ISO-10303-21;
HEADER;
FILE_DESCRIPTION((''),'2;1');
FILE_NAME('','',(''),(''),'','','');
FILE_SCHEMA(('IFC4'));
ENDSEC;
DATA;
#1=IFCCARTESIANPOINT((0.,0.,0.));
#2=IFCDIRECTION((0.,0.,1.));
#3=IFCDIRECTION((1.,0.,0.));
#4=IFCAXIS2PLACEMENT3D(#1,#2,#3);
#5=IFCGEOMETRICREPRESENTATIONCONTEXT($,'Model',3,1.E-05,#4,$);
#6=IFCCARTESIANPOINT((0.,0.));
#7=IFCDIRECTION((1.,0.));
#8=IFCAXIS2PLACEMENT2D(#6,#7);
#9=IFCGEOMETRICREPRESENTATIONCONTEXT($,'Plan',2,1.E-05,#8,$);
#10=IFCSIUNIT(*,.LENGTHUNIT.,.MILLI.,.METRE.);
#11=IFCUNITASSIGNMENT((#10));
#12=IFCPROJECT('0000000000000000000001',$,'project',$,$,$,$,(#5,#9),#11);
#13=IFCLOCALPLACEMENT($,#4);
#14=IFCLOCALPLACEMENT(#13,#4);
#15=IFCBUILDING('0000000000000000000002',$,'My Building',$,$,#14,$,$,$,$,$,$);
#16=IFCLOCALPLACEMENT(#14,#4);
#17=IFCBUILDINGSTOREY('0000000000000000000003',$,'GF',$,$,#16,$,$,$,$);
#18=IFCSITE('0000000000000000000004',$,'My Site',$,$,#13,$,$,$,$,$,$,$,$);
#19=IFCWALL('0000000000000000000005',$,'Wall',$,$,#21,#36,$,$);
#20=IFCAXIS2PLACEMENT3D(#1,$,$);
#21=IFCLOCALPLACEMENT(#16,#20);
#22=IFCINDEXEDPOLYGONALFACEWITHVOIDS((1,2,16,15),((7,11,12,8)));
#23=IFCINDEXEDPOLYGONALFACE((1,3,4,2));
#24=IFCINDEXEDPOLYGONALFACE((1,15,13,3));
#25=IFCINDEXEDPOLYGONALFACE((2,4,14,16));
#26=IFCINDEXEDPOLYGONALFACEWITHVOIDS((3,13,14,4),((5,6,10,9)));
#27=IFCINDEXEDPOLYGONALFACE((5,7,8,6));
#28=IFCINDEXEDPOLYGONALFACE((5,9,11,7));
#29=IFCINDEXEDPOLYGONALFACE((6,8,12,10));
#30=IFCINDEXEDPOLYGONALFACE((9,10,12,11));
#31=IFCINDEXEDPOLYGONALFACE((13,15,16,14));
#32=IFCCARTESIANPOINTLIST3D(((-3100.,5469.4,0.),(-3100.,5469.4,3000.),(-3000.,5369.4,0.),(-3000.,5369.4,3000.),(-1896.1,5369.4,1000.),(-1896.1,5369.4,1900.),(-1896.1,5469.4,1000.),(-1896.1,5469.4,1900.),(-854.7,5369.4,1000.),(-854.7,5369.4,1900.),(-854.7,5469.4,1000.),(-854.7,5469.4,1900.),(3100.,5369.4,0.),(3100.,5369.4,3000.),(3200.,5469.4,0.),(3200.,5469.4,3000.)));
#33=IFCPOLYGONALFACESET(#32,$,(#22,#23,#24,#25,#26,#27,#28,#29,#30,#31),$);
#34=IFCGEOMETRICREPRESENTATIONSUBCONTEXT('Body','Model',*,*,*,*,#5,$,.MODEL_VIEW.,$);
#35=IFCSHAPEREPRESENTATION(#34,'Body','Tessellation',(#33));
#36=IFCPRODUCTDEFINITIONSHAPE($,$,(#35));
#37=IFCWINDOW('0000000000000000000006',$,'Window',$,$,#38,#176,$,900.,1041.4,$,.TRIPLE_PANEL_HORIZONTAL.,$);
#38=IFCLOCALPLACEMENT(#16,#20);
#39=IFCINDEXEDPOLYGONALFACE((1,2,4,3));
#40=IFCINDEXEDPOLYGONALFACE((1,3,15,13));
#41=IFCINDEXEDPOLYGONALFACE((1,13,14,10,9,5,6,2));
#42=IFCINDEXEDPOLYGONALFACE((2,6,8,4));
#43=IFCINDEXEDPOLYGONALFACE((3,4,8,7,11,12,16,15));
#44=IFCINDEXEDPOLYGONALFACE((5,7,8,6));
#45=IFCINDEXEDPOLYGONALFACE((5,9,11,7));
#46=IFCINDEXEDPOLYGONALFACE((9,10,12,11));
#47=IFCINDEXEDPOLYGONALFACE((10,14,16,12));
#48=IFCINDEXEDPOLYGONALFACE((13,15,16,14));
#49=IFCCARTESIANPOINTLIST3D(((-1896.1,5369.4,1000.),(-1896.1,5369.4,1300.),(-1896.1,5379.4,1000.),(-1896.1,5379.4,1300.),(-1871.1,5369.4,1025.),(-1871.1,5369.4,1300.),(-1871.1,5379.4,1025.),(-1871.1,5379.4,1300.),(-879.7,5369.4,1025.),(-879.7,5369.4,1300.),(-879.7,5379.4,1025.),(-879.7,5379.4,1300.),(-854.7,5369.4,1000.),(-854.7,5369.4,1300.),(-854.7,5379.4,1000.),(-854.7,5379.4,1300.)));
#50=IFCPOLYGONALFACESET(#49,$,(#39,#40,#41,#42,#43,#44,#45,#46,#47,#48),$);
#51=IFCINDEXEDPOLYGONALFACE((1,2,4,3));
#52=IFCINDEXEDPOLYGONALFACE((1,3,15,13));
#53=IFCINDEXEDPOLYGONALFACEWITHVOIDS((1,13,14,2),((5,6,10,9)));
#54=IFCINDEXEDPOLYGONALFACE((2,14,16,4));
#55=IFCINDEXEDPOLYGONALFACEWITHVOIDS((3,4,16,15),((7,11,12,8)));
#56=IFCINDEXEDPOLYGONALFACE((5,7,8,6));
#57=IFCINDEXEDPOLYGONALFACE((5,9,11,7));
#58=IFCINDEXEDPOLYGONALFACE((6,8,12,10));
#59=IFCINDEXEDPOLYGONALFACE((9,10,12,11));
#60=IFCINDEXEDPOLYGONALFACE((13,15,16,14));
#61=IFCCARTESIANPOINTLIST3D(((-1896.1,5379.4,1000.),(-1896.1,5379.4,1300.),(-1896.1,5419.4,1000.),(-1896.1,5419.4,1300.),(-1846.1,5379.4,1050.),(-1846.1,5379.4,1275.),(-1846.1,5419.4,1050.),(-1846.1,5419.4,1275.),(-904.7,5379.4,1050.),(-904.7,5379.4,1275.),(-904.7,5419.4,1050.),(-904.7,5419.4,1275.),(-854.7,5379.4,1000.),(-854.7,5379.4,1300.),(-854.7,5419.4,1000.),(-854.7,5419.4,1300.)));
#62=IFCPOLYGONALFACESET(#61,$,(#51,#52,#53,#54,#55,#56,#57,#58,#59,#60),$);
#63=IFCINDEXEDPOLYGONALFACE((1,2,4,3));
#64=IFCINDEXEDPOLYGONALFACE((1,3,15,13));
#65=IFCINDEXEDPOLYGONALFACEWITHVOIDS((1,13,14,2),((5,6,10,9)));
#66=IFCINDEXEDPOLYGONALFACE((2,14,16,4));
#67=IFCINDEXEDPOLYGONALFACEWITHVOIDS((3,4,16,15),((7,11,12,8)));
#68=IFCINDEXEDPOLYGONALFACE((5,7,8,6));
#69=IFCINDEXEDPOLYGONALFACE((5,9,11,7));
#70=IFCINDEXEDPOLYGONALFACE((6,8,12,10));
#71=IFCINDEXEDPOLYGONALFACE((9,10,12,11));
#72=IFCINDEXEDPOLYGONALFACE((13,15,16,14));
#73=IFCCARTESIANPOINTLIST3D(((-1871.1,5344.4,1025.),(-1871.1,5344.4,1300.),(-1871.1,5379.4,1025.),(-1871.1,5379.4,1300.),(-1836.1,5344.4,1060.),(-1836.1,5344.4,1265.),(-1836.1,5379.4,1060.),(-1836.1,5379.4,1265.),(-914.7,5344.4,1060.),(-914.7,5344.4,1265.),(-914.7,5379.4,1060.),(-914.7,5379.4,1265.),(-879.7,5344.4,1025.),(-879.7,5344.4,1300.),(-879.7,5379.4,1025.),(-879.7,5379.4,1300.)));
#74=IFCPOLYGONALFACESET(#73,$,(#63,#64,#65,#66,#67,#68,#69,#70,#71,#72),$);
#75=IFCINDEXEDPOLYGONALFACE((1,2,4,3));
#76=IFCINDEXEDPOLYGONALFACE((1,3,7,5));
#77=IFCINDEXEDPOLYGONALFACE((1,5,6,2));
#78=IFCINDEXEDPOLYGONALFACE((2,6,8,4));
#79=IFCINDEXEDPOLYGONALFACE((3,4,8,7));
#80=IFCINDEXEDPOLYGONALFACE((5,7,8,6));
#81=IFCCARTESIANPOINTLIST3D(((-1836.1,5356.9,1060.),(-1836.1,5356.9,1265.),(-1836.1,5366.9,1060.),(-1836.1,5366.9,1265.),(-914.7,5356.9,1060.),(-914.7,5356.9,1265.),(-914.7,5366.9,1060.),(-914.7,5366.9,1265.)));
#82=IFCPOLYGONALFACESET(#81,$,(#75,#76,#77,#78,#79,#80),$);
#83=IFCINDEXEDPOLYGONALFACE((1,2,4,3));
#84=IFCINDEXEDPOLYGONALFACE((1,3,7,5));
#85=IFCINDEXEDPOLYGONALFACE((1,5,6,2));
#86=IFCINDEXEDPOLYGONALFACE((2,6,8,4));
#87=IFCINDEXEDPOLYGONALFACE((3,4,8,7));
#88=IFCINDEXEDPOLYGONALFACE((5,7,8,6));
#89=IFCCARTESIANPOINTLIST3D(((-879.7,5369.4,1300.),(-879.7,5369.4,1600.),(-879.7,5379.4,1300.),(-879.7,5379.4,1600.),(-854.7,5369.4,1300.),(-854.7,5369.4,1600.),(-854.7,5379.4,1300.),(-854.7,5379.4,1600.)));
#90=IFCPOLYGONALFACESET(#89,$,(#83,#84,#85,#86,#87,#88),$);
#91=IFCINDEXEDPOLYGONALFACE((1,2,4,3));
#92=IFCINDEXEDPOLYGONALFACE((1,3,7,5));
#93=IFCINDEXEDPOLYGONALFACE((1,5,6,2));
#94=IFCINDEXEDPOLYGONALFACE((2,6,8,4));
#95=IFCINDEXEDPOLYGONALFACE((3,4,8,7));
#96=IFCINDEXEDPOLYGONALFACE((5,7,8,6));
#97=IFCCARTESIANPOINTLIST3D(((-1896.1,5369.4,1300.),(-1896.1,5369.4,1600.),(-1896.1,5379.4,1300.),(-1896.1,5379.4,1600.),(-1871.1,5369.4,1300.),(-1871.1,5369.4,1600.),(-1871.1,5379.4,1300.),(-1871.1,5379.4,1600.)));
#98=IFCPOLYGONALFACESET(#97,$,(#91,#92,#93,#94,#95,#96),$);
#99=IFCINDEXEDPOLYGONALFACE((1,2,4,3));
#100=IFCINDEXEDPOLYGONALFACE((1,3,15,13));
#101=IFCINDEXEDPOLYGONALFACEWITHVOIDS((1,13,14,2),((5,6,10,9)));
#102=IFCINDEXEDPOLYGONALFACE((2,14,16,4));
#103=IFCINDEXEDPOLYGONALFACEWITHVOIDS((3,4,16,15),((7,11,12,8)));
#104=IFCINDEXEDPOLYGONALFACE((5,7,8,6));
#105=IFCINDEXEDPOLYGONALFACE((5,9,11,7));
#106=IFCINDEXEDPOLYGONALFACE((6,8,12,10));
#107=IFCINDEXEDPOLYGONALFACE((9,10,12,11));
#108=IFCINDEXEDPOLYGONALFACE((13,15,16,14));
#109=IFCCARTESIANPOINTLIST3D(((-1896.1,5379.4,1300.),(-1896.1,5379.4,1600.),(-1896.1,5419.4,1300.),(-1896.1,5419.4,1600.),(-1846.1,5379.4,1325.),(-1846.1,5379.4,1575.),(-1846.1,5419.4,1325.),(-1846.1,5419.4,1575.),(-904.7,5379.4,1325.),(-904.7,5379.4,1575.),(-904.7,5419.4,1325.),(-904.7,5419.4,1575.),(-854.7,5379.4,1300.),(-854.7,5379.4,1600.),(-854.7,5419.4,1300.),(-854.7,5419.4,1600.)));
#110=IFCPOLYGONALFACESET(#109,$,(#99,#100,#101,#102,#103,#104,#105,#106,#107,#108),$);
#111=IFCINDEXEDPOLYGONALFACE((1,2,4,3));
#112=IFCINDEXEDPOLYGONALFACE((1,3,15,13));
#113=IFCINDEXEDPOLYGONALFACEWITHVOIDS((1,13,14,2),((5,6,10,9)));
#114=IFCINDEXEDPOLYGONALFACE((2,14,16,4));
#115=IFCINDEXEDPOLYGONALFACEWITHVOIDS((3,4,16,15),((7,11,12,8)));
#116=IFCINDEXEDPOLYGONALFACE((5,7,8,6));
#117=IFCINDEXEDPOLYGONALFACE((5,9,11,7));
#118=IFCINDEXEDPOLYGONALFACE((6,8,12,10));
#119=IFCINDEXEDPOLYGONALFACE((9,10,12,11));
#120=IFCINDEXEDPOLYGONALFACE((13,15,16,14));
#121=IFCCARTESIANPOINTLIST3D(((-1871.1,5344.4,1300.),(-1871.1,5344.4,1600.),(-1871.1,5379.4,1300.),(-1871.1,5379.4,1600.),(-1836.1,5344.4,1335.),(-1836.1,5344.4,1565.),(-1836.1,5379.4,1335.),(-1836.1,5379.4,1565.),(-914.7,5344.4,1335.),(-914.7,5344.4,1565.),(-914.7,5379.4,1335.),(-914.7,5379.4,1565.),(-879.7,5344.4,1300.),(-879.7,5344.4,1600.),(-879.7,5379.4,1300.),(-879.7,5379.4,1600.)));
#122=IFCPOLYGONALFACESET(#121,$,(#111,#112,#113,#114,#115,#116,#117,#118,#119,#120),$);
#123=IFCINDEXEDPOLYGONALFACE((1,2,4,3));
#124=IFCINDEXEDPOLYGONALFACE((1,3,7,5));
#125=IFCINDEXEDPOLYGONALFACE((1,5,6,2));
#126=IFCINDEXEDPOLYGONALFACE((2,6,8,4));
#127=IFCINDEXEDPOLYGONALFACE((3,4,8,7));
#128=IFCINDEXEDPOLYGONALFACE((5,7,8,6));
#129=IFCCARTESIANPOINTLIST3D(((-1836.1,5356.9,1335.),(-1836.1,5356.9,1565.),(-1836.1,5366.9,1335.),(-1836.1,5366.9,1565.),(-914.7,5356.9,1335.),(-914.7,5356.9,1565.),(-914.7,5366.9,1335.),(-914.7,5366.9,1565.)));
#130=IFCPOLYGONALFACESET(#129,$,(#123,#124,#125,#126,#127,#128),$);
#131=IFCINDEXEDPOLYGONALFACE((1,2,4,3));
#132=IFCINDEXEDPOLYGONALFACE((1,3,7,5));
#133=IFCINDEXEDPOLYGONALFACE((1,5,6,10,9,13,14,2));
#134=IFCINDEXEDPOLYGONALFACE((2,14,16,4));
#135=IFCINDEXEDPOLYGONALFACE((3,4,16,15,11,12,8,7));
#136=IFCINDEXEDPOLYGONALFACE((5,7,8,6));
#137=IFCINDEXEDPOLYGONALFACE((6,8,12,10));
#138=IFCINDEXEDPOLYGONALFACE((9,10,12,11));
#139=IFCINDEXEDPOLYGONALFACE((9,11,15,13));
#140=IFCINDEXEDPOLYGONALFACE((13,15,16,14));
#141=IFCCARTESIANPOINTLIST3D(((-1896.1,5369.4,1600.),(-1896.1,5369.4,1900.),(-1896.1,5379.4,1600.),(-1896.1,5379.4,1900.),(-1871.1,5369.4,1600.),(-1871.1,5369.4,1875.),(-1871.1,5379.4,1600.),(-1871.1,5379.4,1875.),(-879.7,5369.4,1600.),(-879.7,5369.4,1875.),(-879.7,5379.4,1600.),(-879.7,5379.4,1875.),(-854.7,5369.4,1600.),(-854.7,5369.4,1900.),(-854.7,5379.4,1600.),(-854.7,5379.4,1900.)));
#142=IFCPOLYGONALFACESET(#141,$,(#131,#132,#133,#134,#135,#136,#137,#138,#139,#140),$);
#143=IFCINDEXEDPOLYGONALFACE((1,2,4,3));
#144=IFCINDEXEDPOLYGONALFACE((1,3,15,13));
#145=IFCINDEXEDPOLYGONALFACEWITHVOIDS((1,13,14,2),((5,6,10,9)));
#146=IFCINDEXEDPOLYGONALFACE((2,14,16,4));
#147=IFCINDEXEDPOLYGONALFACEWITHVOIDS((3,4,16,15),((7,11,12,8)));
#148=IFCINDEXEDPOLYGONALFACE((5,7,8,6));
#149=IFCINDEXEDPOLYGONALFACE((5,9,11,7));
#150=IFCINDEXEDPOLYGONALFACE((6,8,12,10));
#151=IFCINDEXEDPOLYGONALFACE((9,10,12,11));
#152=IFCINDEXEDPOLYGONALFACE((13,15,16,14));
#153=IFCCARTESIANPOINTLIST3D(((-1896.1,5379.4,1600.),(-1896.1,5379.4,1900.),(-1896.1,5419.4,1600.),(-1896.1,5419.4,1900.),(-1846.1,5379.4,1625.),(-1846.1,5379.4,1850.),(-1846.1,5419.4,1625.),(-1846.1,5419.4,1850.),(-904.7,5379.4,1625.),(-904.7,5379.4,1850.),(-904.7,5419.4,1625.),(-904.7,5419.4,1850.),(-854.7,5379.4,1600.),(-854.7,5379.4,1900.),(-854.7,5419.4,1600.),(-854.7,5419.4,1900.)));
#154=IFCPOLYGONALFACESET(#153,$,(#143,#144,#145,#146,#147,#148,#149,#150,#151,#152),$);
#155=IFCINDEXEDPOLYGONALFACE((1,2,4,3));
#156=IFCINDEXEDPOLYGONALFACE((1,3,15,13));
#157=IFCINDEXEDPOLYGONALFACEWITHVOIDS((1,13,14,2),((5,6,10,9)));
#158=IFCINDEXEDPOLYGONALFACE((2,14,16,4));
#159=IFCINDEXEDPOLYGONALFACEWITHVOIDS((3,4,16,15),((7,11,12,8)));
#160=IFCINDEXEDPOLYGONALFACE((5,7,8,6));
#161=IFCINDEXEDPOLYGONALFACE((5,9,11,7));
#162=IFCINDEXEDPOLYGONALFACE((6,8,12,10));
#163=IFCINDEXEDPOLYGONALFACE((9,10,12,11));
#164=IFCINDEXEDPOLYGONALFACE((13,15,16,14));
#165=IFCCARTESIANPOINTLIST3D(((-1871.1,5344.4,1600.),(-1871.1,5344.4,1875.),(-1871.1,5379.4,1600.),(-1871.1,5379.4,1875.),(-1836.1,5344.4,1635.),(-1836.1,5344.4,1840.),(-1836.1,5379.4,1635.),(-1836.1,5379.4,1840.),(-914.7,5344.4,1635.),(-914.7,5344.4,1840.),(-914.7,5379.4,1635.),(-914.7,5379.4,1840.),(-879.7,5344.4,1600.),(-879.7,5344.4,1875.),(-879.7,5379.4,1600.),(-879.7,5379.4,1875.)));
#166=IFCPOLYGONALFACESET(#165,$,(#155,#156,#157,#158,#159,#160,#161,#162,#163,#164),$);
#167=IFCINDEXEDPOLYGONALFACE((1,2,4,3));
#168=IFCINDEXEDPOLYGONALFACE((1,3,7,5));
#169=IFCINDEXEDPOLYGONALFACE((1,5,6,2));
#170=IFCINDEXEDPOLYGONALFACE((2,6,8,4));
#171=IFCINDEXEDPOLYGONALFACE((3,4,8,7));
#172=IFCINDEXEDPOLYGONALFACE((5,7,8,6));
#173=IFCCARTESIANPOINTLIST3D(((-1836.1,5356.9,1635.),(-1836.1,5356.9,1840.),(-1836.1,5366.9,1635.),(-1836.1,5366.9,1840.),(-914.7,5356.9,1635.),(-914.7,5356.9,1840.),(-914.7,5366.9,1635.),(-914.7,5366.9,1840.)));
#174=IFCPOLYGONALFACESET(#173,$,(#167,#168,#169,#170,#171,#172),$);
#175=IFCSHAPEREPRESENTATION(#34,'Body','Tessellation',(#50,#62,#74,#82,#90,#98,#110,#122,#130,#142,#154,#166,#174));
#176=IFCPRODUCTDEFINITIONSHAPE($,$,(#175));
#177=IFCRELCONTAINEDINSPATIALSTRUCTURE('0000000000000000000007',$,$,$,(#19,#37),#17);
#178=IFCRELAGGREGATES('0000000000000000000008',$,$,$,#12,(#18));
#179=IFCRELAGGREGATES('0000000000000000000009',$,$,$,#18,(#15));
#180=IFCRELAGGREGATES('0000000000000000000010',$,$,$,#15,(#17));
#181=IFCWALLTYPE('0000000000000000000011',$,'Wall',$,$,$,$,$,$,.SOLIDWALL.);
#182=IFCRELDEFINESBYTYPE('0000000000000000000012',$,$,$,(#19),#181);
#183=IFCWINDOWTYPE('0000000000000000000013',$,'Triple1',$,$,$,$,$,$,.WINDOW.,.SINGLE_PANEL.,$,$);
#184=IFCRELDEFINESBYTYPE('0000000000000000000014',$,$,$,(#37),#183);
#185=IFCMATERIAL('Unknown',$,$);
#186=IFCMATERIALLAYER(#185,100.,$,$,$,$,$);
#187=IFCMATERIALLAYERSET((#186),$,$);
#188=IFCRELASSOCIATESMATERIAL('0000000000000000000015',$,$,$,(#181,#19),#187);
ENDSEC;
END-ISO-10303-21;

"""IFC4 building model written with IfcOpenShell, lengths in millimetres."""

from ifc_helpers import new_model, entity, si_unit, frame, origin_with_axes, origin_2d_with_axis, place, context, subcontext, project, spatial, line, indexed_curve, outline, extrude, shape, source, transform, mapped, material, layer, layer_set, layer_usage, type_object, type_shapes, element, fill, save


model = new_model("IFC4")

# Units and contexts
model_context = context("Model", 3, precision=1e-05, world=origin_with_axes())
plan_context = context("Plan", 2, precision=1e-05, world=origin_2d_with_axis())
body_context_1 = subcontext(model_context, "Body", "Model", "MODEL_VIEW")
body_context_2 = subcontext(plan_context, "Body", "Plan", "PLAN_VIEW")
ifc_project = project(units=[si_unit("LENGTHUNIT", "METRE", prefix="MILLI")], contexts=[model_context, plan_context])

# Site, building, storey
site_placement = place(None, origin_with_axes())
site = spatial("IfcSite", under=ifc_project, at=site_placement, Name="My Site")
building_placement = place(site_placement, origin_with_axes())
building = spatial("IfcBuilding", under=site, at=building_placement, Name="My Building")
storey_placement = place(building_placement, origin_with_axes())
storey = spatial("IfcBuildingStorey", under=building, at=storey_placement, Name="GF")

# Shared definitions
ifc_material = material(Name="Unknown")

# Wall, opening, window
ifc_layer_1 = layer(ifc_material, 100.0)
ifc_layer_set_1 = layer_set([ifc_layer_1])
ifc_layer_usage_1 = layer_usage(ifc_layer_set_1, "AXIS2", "POSITIVE", 0.0)
wall_type = type_object("IfcWallType", Name="Wall", PredefinedType="SOLIDWALL", material=ifc_layer_set_1)
wall_1_placement = place(storey_placement, frame((-3100.0, 5369.4, 0.0), z_axis=(0.0, 0.0, 1.0), x_axis=(1.0, 0.0, 0.0)))
wall_1 = element("IfcWall", 1, at=wall_1_placement, inside=storey, type_object=wall_type, material=ifc_layer_usage_1, Name="Wall", context=body_context_1, shape_type="SweptSolid", body=[
    extrude(outline(indexed_curve([(100.0, 0.0), (0.0, 100.0), (6300.0, 100.0), (6200.0, 0.0)], segments=[line(1, 2, 3, 4, 1)])), origin_with_axes(), (0.0, 0.0, 1.0), 3000.0),
])
shared_shape_1 = source(origin_with_axes(), body_context_1, "Body", "SweptSolid", [
    extrude(outline(indexed_curve([(0.0, 0.0), (1041.4, 0.0), (1041.4, 900.0), (0.0, 900.0)], segments=[line(1, 2, 3, 4, 1)])), frame((0.0, -600.0, 0.0), z_axis=(0.0, -1.0, 0.0), x_axis=(1.0, 0.0, 0.0)), (0.0, 0.0, -1.0), 1200.0),
])
opening_1_placement = place(wall_1_placement, frame((2245.3, 100.0, 1000.0), z_axis=(0.0, 0.0, 1.0), x_axis=(-1.0, 0.0, 0.0)))
opening_1 = element("IfcOpeningElement", 2, at=opening_1_placement, cuts=wall_1, PredefinedType="OPENING", context=body_context_1, shape_type="MappedRepresentation", body=[
    mapped(shared_shape_1, transform((0.0, 0.0, 0.0), x_axis=(1.0, 0.0, 0.0), y_axis=(0.0, 1.0, 0.0), z_axis=(0.0, 0.0, 1.0), scale=1.0)),
])
window_type_1 = type_object("IfcWindowType", Name="Triple1", PartitioningType="SINGLE_PANEL", PredefinedType="WINDOW")
shared_shape_2 = source(origin_with_axes(), body_context_1, "Body", "SweptSolid", [
    extrude(outline(indexed_curve([(1041.4, 300.0), (1041.4, 0.0), (0.0, 0.0), (0.0, 300.0), (25.0, 300.0), (25.0, 25.0), (1016.4, 25.0), (1016.4, 300.0)], segments=[line(1, 2, 3, 4, 5, 6, 7, 8, 1)])), frame((0.0, 90.0, 0.0), z_axis=(0.0, -1.0, 0.0), x_axis=(1.0, 0.0, 0.0)), (0.0, 0.0, -1.0), 10.0),
    extrude(outline(indexed_curve([(0.0, 0.0), (1041.4, 0.0), (1041.4, 300.0), (0.0, 300.0)], segments=[line(1, 2, 3, 4, 1)]), holes=[indexed_curve([(50.0, 50.0), (991.4, 50.0), (991.4, 275.0), (50.0, 275.0)], segments=[line(1, 2, 3, 4, 1)])]), frame((0.0, 50.0, 0.0), z_axis=(0.0, -1.0, 0.0), x_axis=(1.0, 0.0, 0.0)), (0.0, 0.0, -1.0), 40.0),
    extrude(outline(indexed_curve([(0.0, 0.0), (991.4, 0.0), (991.4, 275.0), (0.0, 275.0)], segments=[line(1, 2, 3, 4, 1)]), holes=[indexed_curve([(35.0, 35.0), (956.4, 35.0), (956.4, 240.0), (35.0, 240.0)], segments=[line(1, 2, 3, 4, 1)])]), frame((25.0, 90.0, 25.0), z_axis=(0.0, -1.0, 0.0), x_axis=(1.0, 0.0, 0.0)), (0.0, 0.0, -1.0), 35.0),
    extrude(outline(indexed_curve([(35.0, 35.0), (956.4, 35.0), (956.4, 240.0), (35.0, 240.0)], segments=[line(1, 2, 3, 4, 1)])), frame((25.0, 102.5, 25.0), z_axis=(0.0, -1.0, 0.0), x_axis=(1.0, 0.0, 0.0)), (0.0, 0.0, -1.0), 10.0),
    extrude(outline(indexed_curve([(0.0, 0.0), (0.0, 300.0), (25.0, 300.0), (25.0, 0.0)], segments=[line(1, 2, 3, 4, 1)])), frame((0.0, 90.0, 300.0), z_axis=(0.0, -1.0, 0.0), x_axis=(1.0, 0.0, 0.0)), (0.0, 0.0, -1.0), 10.0),
    extrude(outline(indexed_curve([(1041.4, 300.0), (1041.4, 0.0), (1016.4, 0.0), (1016.4, 300.0)], segments=[line(1, 2, 3, 4, 1)])), frame((0.0, 90.0, 300.0), z_axis=(0.0, -1.0, 0.0), x_axis=(1.0, 0.0, 0.0)), (0.0, 0.0, -1.0), 10.0),
    extrude(outline(indexed_curve([(0.0, 0.0), (1041.4, 0.0), (1041.4, 300.0), (0.0, 300.0)], segments=[line(1, 2, 3, 4, 1)]), holes=[indexed_curve([(50.0, 25.0), (991.4, 25.0), (991.4, 275.0), (50.0, 275.0)], segments=[line(1, 2, 3, 4, 1)])]), frame((0.0, 50.0, 300.0), z_axis=(0.0, -1.0, 0.0), x_axis=(1.0, 0.0, 0.0)), (0.0, 0.0, -1.0), 40.0),
    extrude(outline(indexed_curve([(0.0, 0.0), (991.4, 0.0), (991.4, 300.0), (0.0, 300.0)], segments=[line(1, 2, 3, 4, 1)]), holes=[indexed_curve([(35.0, 35.0), (956.4, 35.0), (956.4, 265.0), (35.0, 265.0)], segments=[line(1, 2, 3, 4, 1)])]), frame((25.0, 90.0, 300.0), z_axis=(0.0, -1.0, 0.0), x_axis=(1.0, 0.0, 0.0)), (0.0, 0.0, -1.0), 35.0),
    extrude(outline(indexed_curve([(35.0, 35.0), (956.4, 35.0), (956.4, 265.0), (35.0, 265.0)], segments=[line(1, 2, 3, 4, 1)])), frame((25.0, 102.5, 300.0), z_axis=(0.0, -1.0, 0.0), x_axis=(1.0, 0.0, 0.0)), (0.0, 0.0, -1.0), 10.0),
    extrude(outline(indexed_curve([(0.0, 0.0), (0.0, 300.0), (1041.4, 300.0), (1041.4, 0.0), (1016.4, 0.0), (1016.4, 275.0), (25.0, 275.0), (25.0, 0.0)], segments=[line(1, 2, 3, 4, 5, 6, 7, 8, 1)])), frame((0.0, 90.0, 600.0), z_axis=(0.0, -1.0, 0.0), x_axis=(1.0, 0.0, 0.0)), (0.0, 0.0, -1.0), 10.0),
    extrude(outline(indexed_curve([(0.0, 0.0), (1041.4, 0.0), (1041.4, 300.0), (0.0, 300.0)], segments=[line(1, 2, 3, 4, 1)]), holes=[indexed_curve([(50.0, 25.0), (991.4, 25.0), (991.4, 250.0), (50.0, 250.0)], segments=[line(1, 2, 3, 4, 1)])]), frame((0.0, 50.0, 600.0), z_axis=(0.0, -1.0, 0.0), x_axis=(1.0, 0.0, 0.0)), (0.0, 0.0, -1.0), 40.0),
    extrude(outline(indexed_curve([(0.0, 0.0), (991.4, 0.0), (991.4, 275.0), (0.0, 275.0)], segments=[line(1, 2, 3, 4, 1)]), holes=[indexed_curve([(35.0, 35.0), (956.4, 35.0), (956.4, 240.0), (35.0, 240.0)], segments=[line(1, 2, 3, 4, 1)])]), frame((25.0, 90.0, 600.0), z_axis=(0.0, -1.0, 0.0), x_axis=(1.0, 0.0, 0.0)), (0.0, 0.0, -1.0), 35.0),
    extrude(outline(indexed_curve([(35.0, 35.0), (956.4, 35.0), (956.4, 240.0), (35.0, 240.0)], segments=[line(1, 2, 3, 4, 1)])), frame((25.0, 102.5, 600.0), z_axis=(0.0, -1.0, 0.0), x_axis=(1.0, 0.0, 0.0)), (0.0, 0.0, -1.0), 10.0),
])
shared_shape_3 = source(origin_with_axes(), body_context_2, "Body", "Curve2D", [
    entity("IfcIndexedPolyCurve", entity("IfcCartesianPointList2D", [[50.0, 50.0], [991.4, 50.0]])),
    entity("IfcIndexedPolyCurve", entity("IfcCartesianPointList2D", [[0.0, 100.0], [25.0, 100.0], [25.0, 90.0], [50.0, 90.0], [50.0, 50.0], [0.0, 50.0]]), [entity("IfcLineIndex", [1, 2, 3, 4, 5, 6, 1])]),
    entity("IfcIndexedPolyCurve", entity("IfcCartesianPointList2D", [[1041.4, 100.0], [1016.4, 100.0], [1016.4, 90.0], [991.4, 90.0], [991.4, 50.0], [1041.4, 50.0]]), [entity("IfcLineIndex", [1, 2, 3, 4, 5, 6, 1])]),
    entity("IfcIndexedPolyCurve", entity("IfcCartesianPointList2D", [[25.0, 90.0], [60.0, 90.0], [60.0, 125.0], [25.0, 125.0]]), [entity("IfcLineIndex", [1, 2, 3, 4, 1])]),
    entity("IfcIndexedPolyCurve", entity("IfcCartesianPointList2D", [[1016.4, 90.0], [981.4, 90.0], [981.4, 125.0], [1016.4, 125.0]]), [entity("IfcLineIndex", [1, 2, 3, 4, 1])]),
    entity("IfcIndexedPolyCurve", entity("IfcCartesianPointList2D", [[60.0, 90.0], [981.4, 90.0]])),
    entity("IfcIndexedPolyCurve", entity("IfcCartesianPointList2D", [[60.0, 125.0], [981.4, 125.0]])),
    entity("IfcIndexedPolyCurve", entity("IfcCartesianPointList2D", [[60.0, 107.5], [981.4, 107.5]])),
])
type_shapes(window_type_1, [shared_shape_2, shared_shape_3])
window_1_placement = place(opening_1_placement, frame((0.0, 0.0, 0.0), z_axis=(0.0, 0.0, 1.0), x_axis=(1.0, 0.0, 0.0)))
window_1 = element("IfcWindow", 3, at=window_1_placement, inside=storey, type_object=window_type_1, Name="Window", OverallHeight=900.0, OverallWidth=1041.4, PartitioningType="TRIPLE_PANEL_HORIZONTAL", shapes=[
    shape(body_context_1, "Body", "MappedRepresentation", [mapped(shared_shape_2, transform((0.0, 0.0, 0.0), x_axis=(1.0, 0.0, 0.0), y_axis=(0.0, 1.0, 0.0), z_axis=(0.0, 0.0, 1.0), scale=1.0))]),
    shape(body_context_2, "Body", "MappedRepresentation", [mapped(shared_shape_3, transform((0.0, 0.0, 0.0), x_axis=(1.0, 0.0, 0.0), y_axis=(0.0, 1.0, 0.0), z_axis=(0.0, 0.0, 1.0), scale=1.0))]),
])
fill(opening_1, window_1)

save(model, "model.ifc")
